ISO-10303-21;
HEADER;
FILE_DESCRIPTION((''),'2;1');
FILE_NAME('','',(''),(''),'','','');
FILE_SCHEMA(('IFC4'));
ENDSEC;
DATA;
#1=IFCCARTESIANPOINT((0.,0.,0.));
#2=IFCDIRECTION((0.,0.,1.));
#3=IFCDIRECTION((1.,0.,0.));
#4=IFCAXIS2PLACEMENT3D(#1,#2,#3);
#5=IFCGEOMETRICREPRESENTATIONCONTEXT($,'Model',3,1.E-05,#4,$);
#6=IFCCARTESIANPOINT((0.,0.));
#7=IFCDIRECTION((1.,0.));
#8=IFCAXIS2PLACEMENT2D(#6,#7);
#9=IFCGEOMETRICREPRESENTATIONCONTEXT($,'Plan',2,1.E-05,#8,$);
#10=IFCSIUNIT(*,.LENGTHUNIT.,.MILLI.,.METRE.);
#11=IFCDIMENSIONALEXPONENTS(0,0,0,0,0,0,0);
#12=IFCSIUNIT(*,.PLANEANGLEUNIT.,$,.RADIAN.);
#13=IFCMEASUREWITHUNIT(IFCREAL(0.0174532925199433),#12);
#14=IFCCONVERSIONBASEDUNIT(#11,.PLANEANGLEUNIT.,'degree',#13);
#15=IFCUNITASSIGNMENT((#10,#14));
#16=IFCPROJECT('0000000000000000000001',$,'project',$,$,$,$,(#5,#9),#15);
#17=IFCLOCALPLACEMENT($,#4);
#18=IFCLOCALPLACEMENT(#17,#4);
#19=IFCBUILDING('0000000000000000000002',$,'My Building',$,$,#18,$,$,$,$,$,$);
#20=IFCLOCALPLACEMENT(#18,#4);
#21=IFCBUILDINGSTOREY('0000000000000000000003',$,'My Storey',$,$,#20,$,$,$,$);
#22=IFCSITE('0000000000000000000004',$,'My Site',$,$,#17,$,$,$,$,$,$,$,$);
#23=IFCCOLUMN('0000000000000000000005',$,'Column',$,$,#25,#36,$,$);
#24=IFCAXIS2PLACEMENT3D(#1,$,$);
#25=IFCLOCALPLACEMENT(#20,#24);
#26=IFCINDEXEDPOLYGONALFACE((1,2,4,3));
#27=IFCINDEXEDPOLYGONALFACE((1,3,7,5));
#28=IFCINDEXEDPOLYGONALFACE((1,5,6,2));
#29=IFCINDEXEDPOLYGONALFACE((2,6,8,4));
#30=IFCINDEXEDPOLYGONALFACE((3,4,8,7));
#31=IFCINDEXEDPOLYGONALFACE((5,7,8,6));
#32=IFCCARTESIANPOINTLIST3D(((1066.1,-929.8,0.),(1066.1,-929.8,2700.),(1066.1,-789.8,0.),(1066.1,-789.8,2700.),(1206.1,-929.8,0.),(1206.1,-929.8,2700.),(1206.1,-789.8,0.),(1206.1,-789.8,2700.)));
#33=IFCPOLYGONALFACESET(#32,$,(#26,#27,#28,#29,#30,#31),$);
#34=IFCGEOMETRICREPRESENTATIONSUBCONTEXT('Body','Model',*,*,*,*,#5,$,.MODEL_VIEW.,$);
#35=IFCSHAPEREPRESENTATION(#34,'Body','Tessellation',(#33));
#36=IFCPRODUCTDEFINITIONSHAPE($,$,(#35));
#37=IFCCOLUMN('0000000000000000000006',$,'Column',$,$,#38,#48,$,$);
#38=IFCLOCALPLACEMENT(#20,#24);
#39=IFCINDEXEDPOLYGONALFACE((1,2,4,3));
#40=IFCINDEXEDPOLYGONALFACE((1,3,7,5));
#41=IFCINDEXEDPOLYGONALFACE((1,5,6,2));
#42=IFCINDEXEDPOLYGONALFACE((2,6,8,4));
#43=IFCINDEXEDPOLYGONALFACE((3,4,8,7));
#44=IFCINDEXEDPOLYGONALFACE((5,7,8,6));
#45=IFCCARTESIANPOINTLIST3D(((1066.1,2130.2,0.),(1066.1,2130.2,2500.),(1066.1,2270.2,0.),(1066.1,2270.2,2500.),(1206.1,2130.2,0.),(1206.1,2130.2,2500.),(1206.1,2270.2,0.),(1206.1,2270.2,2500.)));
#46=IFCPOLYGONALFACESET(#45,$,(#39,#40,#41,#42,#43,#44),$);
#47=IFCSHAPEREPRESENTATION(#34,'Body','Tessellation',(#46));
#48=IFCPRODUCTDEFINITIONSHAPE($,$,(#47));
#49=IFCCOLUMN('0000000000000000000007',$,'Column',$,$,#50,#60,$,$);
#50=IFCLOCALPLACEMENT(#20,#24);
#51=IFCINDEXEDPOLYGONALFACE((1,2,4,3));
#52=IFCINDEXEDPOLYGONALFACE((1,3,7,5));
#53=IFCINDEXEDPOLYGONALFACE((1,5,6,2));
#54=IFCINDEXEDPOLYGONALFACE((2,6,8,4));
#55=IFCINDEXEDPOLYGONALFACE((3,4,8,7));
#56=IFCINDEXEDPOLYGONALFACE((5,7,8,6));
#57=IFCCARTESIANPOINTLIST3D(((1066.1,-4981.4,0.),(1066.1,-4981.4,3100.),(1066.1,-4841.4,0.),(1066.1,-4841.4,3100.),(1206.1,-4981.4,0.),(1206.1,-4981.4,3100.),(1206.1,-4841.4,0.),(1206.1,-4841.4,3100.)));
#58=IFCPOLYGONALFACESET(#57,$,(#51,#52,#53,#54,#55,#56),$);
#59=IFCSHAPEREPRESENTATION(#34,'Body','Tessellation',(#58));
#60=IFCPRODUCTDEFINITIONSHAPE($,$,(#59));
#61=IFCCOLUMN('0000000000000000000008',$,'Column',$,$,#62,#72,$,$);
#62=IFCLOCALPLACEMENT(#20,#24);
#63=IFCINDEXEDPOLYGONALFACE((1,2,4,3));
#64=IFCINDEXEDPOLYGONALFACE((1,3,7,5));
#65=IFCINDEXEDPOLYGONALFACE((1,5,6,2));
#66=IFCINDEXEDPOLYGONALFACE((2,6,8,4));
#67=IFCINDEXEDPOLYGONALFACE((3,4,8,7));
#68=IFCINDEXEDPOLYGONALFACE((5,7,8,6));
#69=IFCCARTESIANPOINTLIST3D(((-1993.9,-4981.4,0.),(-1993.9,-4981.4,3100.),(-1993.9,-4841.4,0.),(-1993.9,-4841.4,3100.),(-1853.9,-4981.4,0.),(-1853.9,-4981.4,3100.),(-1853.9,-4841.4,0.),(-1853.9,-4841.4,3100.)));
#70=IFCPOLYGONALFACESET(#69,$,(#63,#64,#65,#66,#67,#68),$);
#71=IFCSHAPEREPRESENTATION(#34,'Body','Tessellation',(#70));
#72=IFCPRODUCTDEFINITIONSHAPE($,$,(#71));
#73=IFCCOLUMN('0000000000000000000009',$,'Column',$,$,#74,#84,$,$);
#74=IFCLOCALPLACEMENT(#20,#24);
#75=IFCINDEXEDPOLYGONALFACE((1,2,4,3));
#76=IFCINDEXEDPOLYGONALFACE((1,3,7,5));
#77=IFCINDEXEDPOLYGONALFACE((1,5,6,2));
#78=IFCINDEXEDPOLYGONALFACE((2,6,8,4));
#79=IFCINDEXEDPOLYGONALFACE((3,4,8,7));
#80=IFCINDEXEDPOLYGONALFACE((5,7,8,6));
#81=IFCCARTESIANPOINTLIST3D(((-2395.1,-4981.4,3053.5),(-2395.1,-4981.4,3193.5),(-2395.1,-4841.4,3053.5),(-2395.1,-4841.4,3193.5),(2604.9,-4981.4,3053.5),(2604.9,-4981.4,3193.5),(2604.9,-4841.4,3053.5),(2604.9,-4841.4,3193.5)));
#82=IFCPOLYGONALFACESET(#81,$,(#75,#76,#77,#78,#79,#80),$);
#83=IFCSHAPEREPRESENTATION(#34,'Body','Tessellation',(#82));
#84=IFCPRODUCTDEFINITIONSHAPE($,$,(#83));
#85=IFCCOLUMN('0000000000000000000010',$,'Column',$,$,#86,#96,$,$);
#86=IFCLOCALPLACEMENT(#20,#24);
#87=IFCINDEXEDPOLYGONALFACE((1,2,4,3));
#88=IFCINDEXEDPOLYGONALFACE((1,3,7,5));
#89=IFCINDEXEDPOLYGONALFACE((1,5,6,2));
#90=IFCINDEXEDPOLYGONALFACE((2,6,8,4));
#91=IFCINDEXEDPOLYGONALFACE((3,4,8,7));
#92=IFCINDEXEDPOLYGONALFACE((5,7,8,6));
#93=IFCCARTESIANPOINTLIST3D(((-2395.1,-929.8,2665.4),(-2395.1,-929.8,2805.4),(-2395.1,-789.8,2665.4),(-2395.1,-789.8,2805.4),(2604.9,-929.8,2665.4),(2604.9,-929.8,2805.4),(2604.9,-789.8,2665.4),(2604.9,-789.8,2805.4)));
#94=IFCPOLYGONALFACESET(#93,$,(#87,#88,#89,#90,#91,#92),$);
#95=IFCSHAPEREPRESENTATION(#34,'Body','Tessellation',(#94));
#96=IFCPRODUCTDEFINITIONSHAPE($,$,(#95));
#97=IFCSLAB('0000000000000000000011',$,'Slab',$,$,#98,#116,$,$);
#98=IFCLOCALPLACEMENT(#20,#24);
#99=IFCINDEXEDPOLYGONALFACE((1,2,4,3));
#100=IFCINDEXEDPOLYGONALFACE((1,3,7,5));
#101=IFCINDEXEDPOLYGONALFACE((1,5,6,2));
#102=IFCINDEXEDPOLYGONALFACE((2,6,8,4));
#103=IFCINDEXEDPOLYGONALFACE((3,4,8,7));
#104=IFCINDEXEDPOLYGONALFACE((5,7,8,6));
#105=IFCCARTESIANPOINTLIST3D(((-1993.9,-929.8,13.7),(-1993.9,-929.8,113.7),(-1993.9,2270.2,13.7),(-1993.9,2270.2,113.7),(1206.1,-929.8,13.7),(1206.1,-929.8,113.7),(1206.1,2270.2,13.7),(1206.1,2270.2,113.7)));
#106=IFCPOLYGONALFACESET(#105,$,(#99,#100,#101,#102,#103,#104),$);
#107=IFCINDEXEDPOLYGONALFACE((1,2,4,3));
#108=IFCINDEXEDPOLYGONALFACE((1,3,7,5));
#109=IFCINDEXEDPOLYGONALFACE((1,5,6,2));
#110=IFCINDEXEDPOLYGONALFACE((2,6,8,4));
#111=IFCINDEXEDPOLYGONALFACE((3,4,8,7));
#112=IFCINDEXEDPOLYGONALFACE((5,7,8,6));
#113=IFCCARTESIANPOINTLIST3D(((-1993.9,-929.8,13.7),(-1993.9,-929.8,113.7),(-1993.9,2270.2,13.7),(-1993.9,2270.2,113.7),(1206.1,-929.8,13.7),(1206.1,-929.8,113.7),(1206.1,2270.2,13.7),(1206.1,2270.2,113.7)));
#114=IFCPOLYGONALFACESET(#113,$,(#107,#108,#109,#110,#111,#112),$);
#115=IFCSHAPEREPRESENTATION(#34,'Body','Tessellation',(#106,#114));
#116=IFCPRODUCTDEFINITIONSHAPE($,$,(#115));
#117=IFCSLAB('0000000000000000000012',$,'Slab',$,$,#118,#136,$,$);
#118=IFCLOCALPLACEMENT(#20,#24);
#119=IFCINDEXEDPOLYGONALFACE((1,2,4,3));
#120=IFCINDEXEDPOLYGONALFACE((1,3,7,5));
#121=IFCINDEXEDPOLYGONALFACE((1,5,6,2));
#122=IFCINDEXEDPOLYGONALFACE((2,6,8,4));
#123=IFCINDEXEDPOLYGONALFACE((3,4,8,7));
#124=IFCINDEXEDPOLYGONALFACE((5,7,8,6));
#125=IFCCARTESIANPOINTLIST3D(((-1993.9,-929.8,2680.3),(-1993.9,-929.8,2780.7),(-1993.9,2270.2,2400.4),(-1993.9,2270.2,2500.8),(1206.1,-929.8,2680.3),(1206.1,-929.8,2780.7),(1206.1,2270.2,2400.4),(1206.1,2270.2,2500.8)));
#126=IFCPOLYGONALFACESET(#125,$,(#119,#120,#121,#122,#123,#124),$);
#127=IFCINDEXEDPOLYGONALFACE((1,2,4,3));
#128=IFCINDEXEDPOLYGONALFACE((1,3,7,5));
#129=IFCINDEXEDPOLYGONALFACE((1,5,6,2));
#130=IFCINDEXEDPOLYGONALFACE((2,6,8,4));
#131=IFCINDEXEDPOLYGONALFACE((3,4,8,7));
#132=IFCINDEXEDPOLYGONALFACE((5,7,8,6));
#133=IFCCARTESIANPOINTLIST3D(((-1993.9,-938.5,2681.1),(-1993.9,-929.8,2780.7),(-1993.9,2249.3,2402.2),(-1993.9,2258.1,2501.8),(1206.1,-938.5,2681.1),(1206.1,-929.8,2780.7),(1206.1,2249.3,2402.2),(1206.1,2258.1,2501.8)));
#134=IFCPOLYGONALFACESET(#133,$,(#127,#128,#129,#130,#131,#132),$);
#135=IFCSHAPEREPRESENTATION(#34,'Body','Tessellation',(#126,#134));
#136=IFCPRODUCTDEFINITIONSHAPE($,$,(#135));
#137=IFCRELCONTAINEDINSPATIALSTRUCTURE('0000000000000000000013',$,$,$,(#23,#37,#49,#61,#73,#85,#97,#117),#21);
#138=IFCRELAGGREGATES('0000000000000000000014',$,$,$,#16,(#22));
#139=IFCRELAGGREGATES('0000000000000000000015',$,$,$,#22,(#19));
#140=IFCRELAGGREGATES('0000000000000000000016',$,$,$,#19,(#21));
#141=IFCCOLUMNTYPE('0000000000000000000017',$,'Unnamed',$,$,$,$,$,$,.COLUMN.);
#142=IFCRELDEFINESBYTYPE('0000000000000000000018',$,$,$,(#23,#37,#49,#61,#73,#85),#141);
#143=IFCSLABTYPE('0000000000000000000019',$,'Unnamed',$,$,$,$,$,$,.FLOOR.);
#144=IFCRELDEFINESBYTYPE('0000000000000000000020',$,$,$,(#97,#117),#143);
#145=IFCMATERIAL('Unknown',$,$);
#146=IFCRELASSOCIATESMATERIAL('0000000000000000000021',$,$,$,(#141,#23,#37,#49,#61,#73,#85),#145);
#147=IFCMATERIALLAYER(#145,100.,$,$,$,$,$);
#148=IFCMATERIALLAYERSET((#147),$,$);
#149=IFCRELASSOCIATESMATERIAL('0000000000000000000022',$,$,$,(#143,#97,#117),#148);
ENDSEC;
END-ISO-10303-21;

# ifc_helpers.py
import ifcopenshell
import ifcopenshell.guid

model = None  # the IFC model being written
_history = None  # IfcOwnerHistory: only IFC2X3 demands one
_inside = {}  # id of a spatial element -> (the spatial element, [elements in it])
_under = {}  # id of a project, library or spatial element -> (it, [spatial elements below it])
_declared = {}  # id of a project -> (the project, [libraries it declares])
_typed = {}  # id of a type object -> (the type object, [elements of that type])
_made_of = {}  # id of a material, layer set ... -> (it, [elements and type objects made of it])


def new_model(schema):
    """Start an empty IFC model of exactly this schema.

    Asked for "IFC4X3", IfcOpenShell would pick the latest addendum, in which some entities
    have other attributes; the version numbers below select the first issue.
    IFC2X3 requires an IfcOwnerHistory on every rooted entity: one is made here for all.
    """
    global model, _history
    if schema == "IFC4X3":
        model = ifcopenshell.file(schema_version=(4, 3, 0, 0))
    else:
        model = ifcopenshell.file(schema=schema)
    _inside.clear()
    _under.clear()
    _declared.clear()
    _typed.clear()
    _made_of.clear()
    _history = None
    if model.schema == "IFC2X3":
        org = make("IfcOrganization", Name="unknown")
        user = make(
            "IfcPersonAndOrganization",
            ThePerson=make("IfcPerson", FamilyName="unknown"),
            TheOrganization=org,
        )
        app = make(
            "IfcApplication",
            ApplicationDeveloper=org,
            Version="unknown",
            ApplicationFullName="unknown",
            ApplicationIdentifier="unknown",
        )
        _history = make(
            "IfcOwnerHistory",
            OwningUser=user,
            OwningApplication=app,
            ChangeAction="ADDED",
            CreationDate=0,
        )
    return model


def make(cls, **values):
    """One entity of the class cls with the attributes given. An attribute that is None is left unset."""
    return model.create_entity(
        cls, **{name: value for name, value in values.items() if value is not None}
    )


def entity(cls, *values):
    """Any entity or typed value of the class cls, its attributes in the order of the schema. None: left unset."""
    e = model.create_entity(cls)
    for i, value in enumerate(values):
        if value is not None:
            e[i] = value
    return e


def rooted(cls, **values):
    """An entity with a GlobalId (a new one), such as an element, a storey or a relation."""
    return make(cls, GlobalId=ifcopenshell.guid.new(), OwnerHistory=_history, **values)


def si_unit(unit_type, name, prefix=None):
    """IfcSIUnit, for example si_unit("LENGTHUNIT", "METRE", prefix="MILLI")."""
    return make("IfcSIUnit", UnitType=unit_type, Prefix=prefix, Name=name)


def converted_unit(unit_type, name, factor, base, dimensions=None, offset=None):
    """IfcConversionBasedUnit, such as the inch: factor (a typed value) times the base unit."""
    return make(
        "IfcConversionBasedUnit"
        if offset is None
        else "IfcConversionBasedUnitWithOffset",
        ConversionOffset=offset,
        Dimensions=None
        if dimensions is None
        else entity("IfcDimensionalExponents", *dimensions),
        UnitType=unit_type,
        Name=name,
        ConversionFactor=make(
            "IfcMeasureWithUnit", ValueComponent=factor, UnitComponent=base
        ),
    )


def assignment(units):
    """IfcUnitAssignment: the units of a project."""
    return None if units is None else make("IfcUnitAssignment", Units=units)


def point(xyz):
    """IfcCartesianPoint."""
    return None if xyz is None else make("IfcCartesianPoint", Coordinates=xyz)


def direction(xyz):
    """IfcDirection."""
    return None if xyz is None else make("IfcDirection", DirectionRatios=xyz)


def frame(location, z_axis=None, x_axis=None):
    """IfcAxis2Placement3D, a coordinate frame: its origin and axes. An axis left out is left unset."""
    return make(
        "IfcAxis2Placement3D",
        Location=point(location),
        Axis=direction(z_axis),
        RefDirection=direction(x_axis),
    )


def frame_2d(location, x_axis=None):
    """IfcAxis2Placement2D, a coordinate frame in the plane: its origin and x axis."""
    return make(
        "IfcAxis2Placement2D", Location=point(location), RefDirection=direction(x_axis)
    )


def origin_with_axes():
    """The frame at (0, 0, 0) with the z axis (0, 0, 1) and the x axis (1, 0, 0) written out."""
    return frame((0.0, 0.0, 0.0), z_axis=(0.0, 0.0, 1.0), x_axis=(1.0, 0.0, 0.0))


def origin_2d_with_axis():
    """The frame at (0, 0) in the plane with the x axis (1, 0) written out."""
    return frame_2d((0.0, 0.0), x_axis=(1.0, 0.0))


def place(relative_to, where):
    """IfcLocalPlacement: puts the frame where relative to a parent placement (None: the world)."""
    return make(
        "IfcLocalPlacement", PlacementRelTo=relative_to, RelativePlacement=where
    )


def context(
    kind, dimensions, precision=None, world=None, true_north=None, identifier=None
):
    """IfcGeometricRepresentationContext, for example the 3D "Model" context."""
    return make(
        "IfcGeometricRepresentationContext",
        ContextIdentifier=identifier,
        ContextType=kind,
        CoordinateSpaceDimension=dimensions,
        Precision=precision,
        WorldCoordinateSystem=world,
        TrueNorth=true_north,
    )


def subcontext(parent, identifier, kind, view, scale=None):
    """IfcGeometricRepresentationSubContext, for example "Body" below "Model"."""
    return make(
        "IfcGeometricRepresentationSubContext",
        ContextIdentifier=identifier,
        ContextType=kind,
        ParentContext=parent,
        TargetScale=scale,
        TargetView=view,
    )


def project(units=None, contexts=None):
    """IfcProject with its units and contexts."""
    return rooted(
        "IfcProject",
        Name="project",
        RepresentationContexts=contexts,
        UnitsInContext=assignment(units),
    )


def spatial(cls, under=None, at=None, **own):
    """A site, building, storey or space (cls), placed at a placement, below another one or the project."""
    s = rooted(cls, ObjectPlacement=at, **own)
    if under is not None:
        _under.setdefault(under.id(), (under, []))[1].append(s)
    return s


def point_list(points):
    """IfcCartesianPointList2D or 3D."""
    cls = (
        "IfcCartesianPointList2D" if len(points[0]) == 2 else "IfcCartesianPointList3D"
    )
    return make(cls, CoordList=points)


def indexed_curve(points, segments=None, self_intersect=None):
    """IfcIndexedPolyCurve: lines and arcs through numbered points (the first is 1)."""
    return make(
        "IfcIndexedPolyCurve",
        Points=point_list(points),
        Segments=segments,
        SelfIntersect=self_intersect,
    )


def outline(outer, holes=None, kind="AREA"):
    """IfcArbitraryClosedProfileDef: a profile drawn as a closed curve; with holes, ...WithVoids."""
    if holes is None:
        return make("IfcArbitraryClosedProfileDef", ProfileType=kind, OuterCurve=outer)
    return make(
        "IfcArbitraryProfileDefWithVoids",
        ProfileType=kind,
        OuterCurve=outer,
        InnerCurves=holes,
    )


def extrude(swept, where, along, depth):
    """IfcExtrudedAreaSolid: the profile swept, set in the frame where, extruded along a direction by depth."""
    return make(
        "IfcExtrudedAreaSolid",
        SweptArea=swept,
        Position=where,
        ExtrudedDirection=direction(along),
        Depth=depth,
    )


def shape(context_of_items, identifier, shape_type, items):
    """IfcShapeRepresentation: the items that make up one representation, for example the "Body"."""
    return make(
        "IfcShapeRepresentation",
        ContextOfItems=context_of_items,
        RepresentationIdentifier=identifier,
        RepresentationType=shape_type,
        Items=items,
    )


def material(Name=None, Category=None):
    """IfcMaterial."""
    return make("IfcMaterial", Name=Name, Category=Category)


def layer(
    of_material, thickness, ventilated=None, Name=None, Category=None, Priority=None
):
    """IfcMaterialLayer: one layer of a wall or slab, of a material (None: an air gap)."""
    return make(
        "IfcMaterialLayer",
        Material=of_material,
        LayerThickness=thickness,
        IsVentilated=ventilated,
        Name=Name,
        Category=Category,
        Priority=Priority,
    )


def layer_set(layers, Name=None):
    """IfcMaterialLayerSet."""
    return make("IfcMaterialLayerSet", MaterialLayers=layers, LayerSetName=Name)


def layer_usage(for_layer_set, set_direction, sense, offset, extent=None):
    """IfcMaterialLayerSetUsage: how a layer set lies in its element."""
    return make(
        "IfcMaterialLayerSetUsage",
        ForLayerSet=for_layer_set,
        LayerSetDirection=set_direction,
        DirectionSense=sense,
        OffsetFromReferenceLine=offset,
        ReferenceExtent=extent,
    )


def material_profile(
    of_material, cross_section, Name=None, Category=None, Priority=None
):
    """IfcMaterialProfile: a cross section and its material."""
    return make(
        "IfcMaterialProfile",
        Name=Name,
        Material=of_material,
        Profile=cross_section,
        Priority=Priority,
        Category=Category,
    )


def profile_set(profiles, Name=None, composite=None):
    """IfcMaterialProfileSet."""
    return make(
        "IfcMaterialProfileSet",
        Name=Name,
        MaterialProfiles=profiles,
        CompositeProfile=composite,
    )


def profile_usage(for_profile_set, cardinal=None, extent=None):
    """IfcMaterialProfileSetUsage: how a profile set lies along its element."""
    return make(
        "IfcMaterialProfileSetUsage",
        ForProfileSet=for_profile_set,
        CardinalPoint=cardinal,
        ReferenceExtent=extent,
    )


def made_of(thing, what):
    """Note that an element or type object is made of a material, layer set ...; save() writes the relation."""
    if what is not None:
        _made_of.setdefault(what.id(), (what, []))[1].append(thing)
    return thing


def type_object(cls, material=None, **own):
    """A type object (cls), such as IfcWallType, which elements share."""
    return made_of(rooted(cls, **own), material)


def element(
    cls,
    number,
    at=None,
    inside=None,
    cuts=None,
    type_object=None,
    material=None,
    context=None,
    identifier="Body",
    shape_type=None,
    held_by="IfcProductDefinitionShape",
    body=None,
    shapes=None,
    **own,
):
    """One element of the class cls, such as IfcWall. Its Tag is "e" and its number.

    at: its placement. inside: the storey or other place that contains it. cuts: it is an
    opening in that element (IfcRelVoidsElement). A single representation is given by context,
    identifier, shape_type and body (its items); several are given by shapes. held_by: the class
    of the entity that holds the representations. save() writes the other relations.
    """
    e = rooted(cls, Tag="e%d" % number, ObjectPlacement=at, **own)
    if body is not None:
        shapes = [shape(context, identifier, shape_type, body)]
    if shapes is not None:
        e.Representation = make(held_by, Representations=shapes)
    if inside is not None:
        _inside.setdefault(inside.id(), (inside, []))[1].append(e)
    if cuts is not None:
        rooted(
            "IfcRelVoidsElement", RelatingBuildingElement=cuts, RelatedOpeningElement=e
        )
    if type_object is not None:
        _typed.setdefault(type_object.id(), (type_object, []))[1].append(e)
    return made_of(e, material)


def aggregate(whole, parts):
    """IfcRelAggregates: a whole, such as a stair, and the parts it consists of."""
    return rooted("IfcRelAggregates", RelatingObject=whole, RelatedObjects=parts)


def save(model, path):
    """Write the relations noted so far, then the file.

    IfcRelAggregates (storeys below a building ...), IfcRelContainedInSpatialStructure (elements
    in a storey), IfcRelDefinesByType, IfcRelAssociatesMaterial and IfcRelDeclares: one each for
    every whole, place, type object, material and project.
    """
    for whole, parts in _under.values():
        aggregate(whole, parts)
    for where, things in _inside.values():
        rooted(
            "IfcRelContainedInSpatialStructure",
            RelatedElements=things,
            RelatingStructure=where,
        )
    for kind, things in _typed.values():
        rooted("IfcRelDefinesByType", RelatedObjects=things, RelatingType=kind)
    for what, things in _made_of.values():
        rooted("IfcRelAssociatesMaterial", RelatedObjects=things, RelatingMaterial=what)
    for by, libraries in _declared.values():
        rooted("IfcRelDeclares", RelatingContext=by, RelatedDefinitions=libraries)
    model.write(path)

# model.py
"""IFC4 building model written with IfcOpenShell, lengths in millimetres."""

from ifc_helpers import new_model, entity, si_unit, converted_unit, frame, origin_with_axes, origin_2d_with_axis, place, context, subcontext, project, spatial, indexed_curve, outline, extrude, material, layer, layer_set, layer_usage, material_profile, profile_set, profile_usage, type_object, element, save


model = new_model("IFC4")

# Units and contexts
model_context = context("Model", 3, precision=1e-05, world=origin_with_axes())
plan_context = context("Plan", 2, precision=1e-05, world=origin_2d_with_axis())
body_context = subcontext(model_context, "Body", "Model", "MODEL_VIEW")
ifc_project = project(units=[si_unit("LENGTHUNIT", "METRE", prefix="MILLI"), converted_unit("PLANEANGLEUNIT", "degree", entity("IfcReal", 0.0174532925199433), si_unit("PLANEANGLEUNIT", "RADIAN"), dimensions=[0, 0, 0, 0, 0, 0, 0])], contexts=[model_context, plan_context])

# Site, building, storey
site_placement = place(None, origin_with_axes())
site = spatial("IfcSite", under=ifc_project, at=site_placement, Name="My Site")
building_placement = place(site_placement, origin_with_axes())
building = spatial("IfcBuilding", under=site, at=building_placement, Name="My Building")
storey_placement = place(building_placement, origin_with_axes())
storey = spatial("IfcBuildingStorey", under=building, at=storey_placement, Name="My Storey")

# Columns
ifc_material = material(Name="Unknown")
ifc_material_profile = material_profile(ifc_material, outline(indexed_curve([(0.0, 0.0), (140.0, 0.0), (140.0, 140.0), (0.0, 140.0), (0.0, 0.0)])))
ifc_profile_set = profile_set([ifc_material_profile])
ifc_profile_usage_1 = profile_usage(ifc_profile_set, cardinal=5)
column_type = type_object("IfcColumnType", Name="Unnamed", PredefinedType="COLUMN", material=ifc_profile_set)
column_1_placement = place(storey_placement, frame((1066.1, -929.8, 0.0), z_axis=(0.0, 0.0, 1.0), x_axis=(1.0, 0.0, 0.0)))
element("IfcColumn", 1, at=column_1_placement, inside=storey, type_object=column_type, material=ifc_profile_usage_1, Name="Column", context=body_context, shape_type="SweptSolid", body=[
    extrude(outline(indexed_curve([(0.0, 0.0), (140.0, 0.0), (140.0, 140.0), (0.0, 140.0), (0.0, 0.0)])), origin_with_axes(), (0.0, 0.0, 1.0), 2700.0),
])
ifc_profile_usage_2 = profile_usage(ifc_profile_set, cardinal=5)
column_2_placement = place(storey_placement, frame((1066.1, 2130.2, 0.0), z_axis=(0.0, 0.0, 1.0), x_axis=(1.0, 0.0, 0.0)))
element("IfcColumn", 2, at=column_2_placement, inside=storey, type_object=column_type, material=ifc_profile_usage_2, Name="Column", context=body_context, shape_type="SweptSolid", body=[
    extrude(outline(indexed_curve([(0.0, 0.0), (140.0, 0.0), (140.0, 140.0), (0.0, 140.0), (0.0, 0.0)])), origin_with_axes(), (0.0, 0.0, 1.0), 2500.0),
])
ifc_profile_usage_3 = profile_usage(ifc_profile_set, cardinal=5)
column_3_placement = place(storey_placement, frame((1066.1, -4981.4, 0.0), z_axis=(0.0, 0.0, 1.0), x_axis=(1.0, 0.0, 0.0)))
element("IfcColumn", 3, at=column_3_placement, inside=storey, type_object=column_type, material=ifc_profile_usage_3, Name="Column", context=body_context, shape_type="SweptSolid", body=[
    extrude(outline(indexed_curve([(0.0, 0.0), (140.0, 0.0), (140.0, 140.0), (0.0, 140.0), (0.0, 0.0)])), origin_with_axes(), (0.0, 0.0, 1.0), 3100.0),
])
ifc_profile_usage_4 = profile_usage(ifc_profile_set, cardinal=5)
column_4_placement = place(storey_placement, frame((-1993.9, -4981.4, 0.0), z_axis=(0.0, 0.0, 1.0), x_axis=(1.0, 0.0, 0.0)))
element("IfcColumn", 4, at=column_4_placement, inside=storey, type_object=column_type, material=ifc_profile_usage_4, Name="Column", context=body_context, shape_type="SweptSolid", body=[
    extrude(outline(indexed_curve([(0.0, 0.0), (140.0, 0.0), (140.0, 140.0), (0.0, 140.0), (0.0, 0.0)])), origin_with_axes(), (0.0, 0.0, 1.0), 3100.0),
])
ifc_profile_usage_5 = profile_usage(ifc_profile_set, cardinal=5)
column_5_placement = place(storey_placement, frame((-2395.1, -4981.4, 3193.5), z_axis=(1.0, 0.0, 0.0), x_axis=(0.0, 0.0, -1.0)))
element("IfcColumn", 5, at=column_5_placement, inside=storey, type_object=column_type, material=ifc_profile_usage_5, Name="Column", context=body_context, shape_type="SweptSolid", body=[
    extrude(outline(indexed_curve([(0.0, 0.0), (140.0, 0.0), (140.0, 140.0), (0.0, 140.0), (0.0, 0.0)])), origin_with_axes(), (0.0, 0.0, 1.0), 5000.0),
])
ifc_profile_usage_6 = profile_usage(ifc_profile_set, cardinal=5)
column_6_placement = place(storey_placement, frame((-2395.1, -929.8, 2805.4), z_axis=(1.0, 0.0, 0.0), x_axis=(0.0, 0.0, -1.0)))
element("IfcColumn", 6, at=column_6_placement, inside=storey, type_object=column_type, material=ifc_profile_usage_6, Name="Column", context=body_context, shape_type="SweptSolid", body=[
    extrude(outline(indexed_curve([(0.0, 0.0), (140.0, 0.0), (140.0, 140.0), (0.0, 140.0), (0.0, 0.0)])), origin_with_axes(), (0.0, 0.0, 1.0), 5000.0),
])

# Slabs
ifc_layer = layer(ifc_material, 100.0)
ifc_layer_set = layer_set([ifc_layer])
ifc_layer_usage_1 = layer_usage(ifc_layer_set, "AXIS3", "POSITIVE", -100.0)
slab_type = type_object("IfcSlabType", Name="Unnamed", PredefinedType="FLOOR", material=ifc_layer_set)
slab_1_placement = place(storey_placement, frame((-1993.9, -929.8, 113.7), z_axis=(0.0, 0.0, 1.0), x_axis=(1.0, 0.0, 0.0)))
element("IfcSlab", 7, at=slab_1_placement, inside=storey, type_object=slab_type, material=ifc_layer_usage_1, Name="Slab", context=body_context, shape_type="SweptSolid", body=[
    extrude(outline(indexed_curve([(3200.0, 3200.0), (3200.0, 0.0), (0.0, 0.0), (0.0, 3200.0), (3200.0, 3200.0)])), frame((0.0, 0.0, -100.0), z_axis=(0.0, 0.0, 1.0), x_axis=(1.0, 0.0, 0.0)), (0.0, 0.0, 1.0), 100.0),
    extrude(outline(indexed_curve([(0.0, 3200.0), (0.0, 0.0), (3200.0, 0.0), (3200.0, 3200.0), (0.0, 3200.0)])), frame((0.0, 0.0, -100.0), z_axis=(0.0, 0.0, 1.0), x_axis=(1.0, 0.0, 0.0)), (0.0, 0.0, 1.0), 100.0),
])
ifc_layer_usage_2 = layer_usage(ifc_layer_set, "AXIS3", "POSITIVE", -100.0)
slab_2_placement = place(storey_placement, frame((-1993.9, -929.8, 2780.7), z_axis=(0.0, 0.087156, 0.996195), x_axis=(1.0, 0.0, 0.0)))
element("IfcSlab", 8, at=slab_2_placement, inside=storey, type_object=slab_type, material=ifc_layer_usage_2, Name="Slab", context=body_context, shape_type="SweptSolid", body=[
    extrude(outline(indexed_curve([(0.0, 3212.2), (0.0, 0.0), (3200.0, 0.0), (3200.0, 3212.2), (0.0, 3212.2)])), frame((0.0, 8.7, -100.0), z_axis=(0.0, 0.0, 1.0), x_axis=(1.0, 0.0, 0.0)), (0.0, -0.087156, 0.996195), 100.4),
    extrude(outline(indexed_curve([(3200.0, 3200.0), (3200.0, 0.0), (0.0, 0.0), (0.0, 3200.0), (3200.0, 3200.0)])), frame((0.0, 0.0, -100.0), z_axis=(0.0, 0.0, 1.0), x_axis=(1.0, 0.0, 0.0)), (0.0, 0.0, 1.0), 100.0),
])

save(model, "model.ifc")
